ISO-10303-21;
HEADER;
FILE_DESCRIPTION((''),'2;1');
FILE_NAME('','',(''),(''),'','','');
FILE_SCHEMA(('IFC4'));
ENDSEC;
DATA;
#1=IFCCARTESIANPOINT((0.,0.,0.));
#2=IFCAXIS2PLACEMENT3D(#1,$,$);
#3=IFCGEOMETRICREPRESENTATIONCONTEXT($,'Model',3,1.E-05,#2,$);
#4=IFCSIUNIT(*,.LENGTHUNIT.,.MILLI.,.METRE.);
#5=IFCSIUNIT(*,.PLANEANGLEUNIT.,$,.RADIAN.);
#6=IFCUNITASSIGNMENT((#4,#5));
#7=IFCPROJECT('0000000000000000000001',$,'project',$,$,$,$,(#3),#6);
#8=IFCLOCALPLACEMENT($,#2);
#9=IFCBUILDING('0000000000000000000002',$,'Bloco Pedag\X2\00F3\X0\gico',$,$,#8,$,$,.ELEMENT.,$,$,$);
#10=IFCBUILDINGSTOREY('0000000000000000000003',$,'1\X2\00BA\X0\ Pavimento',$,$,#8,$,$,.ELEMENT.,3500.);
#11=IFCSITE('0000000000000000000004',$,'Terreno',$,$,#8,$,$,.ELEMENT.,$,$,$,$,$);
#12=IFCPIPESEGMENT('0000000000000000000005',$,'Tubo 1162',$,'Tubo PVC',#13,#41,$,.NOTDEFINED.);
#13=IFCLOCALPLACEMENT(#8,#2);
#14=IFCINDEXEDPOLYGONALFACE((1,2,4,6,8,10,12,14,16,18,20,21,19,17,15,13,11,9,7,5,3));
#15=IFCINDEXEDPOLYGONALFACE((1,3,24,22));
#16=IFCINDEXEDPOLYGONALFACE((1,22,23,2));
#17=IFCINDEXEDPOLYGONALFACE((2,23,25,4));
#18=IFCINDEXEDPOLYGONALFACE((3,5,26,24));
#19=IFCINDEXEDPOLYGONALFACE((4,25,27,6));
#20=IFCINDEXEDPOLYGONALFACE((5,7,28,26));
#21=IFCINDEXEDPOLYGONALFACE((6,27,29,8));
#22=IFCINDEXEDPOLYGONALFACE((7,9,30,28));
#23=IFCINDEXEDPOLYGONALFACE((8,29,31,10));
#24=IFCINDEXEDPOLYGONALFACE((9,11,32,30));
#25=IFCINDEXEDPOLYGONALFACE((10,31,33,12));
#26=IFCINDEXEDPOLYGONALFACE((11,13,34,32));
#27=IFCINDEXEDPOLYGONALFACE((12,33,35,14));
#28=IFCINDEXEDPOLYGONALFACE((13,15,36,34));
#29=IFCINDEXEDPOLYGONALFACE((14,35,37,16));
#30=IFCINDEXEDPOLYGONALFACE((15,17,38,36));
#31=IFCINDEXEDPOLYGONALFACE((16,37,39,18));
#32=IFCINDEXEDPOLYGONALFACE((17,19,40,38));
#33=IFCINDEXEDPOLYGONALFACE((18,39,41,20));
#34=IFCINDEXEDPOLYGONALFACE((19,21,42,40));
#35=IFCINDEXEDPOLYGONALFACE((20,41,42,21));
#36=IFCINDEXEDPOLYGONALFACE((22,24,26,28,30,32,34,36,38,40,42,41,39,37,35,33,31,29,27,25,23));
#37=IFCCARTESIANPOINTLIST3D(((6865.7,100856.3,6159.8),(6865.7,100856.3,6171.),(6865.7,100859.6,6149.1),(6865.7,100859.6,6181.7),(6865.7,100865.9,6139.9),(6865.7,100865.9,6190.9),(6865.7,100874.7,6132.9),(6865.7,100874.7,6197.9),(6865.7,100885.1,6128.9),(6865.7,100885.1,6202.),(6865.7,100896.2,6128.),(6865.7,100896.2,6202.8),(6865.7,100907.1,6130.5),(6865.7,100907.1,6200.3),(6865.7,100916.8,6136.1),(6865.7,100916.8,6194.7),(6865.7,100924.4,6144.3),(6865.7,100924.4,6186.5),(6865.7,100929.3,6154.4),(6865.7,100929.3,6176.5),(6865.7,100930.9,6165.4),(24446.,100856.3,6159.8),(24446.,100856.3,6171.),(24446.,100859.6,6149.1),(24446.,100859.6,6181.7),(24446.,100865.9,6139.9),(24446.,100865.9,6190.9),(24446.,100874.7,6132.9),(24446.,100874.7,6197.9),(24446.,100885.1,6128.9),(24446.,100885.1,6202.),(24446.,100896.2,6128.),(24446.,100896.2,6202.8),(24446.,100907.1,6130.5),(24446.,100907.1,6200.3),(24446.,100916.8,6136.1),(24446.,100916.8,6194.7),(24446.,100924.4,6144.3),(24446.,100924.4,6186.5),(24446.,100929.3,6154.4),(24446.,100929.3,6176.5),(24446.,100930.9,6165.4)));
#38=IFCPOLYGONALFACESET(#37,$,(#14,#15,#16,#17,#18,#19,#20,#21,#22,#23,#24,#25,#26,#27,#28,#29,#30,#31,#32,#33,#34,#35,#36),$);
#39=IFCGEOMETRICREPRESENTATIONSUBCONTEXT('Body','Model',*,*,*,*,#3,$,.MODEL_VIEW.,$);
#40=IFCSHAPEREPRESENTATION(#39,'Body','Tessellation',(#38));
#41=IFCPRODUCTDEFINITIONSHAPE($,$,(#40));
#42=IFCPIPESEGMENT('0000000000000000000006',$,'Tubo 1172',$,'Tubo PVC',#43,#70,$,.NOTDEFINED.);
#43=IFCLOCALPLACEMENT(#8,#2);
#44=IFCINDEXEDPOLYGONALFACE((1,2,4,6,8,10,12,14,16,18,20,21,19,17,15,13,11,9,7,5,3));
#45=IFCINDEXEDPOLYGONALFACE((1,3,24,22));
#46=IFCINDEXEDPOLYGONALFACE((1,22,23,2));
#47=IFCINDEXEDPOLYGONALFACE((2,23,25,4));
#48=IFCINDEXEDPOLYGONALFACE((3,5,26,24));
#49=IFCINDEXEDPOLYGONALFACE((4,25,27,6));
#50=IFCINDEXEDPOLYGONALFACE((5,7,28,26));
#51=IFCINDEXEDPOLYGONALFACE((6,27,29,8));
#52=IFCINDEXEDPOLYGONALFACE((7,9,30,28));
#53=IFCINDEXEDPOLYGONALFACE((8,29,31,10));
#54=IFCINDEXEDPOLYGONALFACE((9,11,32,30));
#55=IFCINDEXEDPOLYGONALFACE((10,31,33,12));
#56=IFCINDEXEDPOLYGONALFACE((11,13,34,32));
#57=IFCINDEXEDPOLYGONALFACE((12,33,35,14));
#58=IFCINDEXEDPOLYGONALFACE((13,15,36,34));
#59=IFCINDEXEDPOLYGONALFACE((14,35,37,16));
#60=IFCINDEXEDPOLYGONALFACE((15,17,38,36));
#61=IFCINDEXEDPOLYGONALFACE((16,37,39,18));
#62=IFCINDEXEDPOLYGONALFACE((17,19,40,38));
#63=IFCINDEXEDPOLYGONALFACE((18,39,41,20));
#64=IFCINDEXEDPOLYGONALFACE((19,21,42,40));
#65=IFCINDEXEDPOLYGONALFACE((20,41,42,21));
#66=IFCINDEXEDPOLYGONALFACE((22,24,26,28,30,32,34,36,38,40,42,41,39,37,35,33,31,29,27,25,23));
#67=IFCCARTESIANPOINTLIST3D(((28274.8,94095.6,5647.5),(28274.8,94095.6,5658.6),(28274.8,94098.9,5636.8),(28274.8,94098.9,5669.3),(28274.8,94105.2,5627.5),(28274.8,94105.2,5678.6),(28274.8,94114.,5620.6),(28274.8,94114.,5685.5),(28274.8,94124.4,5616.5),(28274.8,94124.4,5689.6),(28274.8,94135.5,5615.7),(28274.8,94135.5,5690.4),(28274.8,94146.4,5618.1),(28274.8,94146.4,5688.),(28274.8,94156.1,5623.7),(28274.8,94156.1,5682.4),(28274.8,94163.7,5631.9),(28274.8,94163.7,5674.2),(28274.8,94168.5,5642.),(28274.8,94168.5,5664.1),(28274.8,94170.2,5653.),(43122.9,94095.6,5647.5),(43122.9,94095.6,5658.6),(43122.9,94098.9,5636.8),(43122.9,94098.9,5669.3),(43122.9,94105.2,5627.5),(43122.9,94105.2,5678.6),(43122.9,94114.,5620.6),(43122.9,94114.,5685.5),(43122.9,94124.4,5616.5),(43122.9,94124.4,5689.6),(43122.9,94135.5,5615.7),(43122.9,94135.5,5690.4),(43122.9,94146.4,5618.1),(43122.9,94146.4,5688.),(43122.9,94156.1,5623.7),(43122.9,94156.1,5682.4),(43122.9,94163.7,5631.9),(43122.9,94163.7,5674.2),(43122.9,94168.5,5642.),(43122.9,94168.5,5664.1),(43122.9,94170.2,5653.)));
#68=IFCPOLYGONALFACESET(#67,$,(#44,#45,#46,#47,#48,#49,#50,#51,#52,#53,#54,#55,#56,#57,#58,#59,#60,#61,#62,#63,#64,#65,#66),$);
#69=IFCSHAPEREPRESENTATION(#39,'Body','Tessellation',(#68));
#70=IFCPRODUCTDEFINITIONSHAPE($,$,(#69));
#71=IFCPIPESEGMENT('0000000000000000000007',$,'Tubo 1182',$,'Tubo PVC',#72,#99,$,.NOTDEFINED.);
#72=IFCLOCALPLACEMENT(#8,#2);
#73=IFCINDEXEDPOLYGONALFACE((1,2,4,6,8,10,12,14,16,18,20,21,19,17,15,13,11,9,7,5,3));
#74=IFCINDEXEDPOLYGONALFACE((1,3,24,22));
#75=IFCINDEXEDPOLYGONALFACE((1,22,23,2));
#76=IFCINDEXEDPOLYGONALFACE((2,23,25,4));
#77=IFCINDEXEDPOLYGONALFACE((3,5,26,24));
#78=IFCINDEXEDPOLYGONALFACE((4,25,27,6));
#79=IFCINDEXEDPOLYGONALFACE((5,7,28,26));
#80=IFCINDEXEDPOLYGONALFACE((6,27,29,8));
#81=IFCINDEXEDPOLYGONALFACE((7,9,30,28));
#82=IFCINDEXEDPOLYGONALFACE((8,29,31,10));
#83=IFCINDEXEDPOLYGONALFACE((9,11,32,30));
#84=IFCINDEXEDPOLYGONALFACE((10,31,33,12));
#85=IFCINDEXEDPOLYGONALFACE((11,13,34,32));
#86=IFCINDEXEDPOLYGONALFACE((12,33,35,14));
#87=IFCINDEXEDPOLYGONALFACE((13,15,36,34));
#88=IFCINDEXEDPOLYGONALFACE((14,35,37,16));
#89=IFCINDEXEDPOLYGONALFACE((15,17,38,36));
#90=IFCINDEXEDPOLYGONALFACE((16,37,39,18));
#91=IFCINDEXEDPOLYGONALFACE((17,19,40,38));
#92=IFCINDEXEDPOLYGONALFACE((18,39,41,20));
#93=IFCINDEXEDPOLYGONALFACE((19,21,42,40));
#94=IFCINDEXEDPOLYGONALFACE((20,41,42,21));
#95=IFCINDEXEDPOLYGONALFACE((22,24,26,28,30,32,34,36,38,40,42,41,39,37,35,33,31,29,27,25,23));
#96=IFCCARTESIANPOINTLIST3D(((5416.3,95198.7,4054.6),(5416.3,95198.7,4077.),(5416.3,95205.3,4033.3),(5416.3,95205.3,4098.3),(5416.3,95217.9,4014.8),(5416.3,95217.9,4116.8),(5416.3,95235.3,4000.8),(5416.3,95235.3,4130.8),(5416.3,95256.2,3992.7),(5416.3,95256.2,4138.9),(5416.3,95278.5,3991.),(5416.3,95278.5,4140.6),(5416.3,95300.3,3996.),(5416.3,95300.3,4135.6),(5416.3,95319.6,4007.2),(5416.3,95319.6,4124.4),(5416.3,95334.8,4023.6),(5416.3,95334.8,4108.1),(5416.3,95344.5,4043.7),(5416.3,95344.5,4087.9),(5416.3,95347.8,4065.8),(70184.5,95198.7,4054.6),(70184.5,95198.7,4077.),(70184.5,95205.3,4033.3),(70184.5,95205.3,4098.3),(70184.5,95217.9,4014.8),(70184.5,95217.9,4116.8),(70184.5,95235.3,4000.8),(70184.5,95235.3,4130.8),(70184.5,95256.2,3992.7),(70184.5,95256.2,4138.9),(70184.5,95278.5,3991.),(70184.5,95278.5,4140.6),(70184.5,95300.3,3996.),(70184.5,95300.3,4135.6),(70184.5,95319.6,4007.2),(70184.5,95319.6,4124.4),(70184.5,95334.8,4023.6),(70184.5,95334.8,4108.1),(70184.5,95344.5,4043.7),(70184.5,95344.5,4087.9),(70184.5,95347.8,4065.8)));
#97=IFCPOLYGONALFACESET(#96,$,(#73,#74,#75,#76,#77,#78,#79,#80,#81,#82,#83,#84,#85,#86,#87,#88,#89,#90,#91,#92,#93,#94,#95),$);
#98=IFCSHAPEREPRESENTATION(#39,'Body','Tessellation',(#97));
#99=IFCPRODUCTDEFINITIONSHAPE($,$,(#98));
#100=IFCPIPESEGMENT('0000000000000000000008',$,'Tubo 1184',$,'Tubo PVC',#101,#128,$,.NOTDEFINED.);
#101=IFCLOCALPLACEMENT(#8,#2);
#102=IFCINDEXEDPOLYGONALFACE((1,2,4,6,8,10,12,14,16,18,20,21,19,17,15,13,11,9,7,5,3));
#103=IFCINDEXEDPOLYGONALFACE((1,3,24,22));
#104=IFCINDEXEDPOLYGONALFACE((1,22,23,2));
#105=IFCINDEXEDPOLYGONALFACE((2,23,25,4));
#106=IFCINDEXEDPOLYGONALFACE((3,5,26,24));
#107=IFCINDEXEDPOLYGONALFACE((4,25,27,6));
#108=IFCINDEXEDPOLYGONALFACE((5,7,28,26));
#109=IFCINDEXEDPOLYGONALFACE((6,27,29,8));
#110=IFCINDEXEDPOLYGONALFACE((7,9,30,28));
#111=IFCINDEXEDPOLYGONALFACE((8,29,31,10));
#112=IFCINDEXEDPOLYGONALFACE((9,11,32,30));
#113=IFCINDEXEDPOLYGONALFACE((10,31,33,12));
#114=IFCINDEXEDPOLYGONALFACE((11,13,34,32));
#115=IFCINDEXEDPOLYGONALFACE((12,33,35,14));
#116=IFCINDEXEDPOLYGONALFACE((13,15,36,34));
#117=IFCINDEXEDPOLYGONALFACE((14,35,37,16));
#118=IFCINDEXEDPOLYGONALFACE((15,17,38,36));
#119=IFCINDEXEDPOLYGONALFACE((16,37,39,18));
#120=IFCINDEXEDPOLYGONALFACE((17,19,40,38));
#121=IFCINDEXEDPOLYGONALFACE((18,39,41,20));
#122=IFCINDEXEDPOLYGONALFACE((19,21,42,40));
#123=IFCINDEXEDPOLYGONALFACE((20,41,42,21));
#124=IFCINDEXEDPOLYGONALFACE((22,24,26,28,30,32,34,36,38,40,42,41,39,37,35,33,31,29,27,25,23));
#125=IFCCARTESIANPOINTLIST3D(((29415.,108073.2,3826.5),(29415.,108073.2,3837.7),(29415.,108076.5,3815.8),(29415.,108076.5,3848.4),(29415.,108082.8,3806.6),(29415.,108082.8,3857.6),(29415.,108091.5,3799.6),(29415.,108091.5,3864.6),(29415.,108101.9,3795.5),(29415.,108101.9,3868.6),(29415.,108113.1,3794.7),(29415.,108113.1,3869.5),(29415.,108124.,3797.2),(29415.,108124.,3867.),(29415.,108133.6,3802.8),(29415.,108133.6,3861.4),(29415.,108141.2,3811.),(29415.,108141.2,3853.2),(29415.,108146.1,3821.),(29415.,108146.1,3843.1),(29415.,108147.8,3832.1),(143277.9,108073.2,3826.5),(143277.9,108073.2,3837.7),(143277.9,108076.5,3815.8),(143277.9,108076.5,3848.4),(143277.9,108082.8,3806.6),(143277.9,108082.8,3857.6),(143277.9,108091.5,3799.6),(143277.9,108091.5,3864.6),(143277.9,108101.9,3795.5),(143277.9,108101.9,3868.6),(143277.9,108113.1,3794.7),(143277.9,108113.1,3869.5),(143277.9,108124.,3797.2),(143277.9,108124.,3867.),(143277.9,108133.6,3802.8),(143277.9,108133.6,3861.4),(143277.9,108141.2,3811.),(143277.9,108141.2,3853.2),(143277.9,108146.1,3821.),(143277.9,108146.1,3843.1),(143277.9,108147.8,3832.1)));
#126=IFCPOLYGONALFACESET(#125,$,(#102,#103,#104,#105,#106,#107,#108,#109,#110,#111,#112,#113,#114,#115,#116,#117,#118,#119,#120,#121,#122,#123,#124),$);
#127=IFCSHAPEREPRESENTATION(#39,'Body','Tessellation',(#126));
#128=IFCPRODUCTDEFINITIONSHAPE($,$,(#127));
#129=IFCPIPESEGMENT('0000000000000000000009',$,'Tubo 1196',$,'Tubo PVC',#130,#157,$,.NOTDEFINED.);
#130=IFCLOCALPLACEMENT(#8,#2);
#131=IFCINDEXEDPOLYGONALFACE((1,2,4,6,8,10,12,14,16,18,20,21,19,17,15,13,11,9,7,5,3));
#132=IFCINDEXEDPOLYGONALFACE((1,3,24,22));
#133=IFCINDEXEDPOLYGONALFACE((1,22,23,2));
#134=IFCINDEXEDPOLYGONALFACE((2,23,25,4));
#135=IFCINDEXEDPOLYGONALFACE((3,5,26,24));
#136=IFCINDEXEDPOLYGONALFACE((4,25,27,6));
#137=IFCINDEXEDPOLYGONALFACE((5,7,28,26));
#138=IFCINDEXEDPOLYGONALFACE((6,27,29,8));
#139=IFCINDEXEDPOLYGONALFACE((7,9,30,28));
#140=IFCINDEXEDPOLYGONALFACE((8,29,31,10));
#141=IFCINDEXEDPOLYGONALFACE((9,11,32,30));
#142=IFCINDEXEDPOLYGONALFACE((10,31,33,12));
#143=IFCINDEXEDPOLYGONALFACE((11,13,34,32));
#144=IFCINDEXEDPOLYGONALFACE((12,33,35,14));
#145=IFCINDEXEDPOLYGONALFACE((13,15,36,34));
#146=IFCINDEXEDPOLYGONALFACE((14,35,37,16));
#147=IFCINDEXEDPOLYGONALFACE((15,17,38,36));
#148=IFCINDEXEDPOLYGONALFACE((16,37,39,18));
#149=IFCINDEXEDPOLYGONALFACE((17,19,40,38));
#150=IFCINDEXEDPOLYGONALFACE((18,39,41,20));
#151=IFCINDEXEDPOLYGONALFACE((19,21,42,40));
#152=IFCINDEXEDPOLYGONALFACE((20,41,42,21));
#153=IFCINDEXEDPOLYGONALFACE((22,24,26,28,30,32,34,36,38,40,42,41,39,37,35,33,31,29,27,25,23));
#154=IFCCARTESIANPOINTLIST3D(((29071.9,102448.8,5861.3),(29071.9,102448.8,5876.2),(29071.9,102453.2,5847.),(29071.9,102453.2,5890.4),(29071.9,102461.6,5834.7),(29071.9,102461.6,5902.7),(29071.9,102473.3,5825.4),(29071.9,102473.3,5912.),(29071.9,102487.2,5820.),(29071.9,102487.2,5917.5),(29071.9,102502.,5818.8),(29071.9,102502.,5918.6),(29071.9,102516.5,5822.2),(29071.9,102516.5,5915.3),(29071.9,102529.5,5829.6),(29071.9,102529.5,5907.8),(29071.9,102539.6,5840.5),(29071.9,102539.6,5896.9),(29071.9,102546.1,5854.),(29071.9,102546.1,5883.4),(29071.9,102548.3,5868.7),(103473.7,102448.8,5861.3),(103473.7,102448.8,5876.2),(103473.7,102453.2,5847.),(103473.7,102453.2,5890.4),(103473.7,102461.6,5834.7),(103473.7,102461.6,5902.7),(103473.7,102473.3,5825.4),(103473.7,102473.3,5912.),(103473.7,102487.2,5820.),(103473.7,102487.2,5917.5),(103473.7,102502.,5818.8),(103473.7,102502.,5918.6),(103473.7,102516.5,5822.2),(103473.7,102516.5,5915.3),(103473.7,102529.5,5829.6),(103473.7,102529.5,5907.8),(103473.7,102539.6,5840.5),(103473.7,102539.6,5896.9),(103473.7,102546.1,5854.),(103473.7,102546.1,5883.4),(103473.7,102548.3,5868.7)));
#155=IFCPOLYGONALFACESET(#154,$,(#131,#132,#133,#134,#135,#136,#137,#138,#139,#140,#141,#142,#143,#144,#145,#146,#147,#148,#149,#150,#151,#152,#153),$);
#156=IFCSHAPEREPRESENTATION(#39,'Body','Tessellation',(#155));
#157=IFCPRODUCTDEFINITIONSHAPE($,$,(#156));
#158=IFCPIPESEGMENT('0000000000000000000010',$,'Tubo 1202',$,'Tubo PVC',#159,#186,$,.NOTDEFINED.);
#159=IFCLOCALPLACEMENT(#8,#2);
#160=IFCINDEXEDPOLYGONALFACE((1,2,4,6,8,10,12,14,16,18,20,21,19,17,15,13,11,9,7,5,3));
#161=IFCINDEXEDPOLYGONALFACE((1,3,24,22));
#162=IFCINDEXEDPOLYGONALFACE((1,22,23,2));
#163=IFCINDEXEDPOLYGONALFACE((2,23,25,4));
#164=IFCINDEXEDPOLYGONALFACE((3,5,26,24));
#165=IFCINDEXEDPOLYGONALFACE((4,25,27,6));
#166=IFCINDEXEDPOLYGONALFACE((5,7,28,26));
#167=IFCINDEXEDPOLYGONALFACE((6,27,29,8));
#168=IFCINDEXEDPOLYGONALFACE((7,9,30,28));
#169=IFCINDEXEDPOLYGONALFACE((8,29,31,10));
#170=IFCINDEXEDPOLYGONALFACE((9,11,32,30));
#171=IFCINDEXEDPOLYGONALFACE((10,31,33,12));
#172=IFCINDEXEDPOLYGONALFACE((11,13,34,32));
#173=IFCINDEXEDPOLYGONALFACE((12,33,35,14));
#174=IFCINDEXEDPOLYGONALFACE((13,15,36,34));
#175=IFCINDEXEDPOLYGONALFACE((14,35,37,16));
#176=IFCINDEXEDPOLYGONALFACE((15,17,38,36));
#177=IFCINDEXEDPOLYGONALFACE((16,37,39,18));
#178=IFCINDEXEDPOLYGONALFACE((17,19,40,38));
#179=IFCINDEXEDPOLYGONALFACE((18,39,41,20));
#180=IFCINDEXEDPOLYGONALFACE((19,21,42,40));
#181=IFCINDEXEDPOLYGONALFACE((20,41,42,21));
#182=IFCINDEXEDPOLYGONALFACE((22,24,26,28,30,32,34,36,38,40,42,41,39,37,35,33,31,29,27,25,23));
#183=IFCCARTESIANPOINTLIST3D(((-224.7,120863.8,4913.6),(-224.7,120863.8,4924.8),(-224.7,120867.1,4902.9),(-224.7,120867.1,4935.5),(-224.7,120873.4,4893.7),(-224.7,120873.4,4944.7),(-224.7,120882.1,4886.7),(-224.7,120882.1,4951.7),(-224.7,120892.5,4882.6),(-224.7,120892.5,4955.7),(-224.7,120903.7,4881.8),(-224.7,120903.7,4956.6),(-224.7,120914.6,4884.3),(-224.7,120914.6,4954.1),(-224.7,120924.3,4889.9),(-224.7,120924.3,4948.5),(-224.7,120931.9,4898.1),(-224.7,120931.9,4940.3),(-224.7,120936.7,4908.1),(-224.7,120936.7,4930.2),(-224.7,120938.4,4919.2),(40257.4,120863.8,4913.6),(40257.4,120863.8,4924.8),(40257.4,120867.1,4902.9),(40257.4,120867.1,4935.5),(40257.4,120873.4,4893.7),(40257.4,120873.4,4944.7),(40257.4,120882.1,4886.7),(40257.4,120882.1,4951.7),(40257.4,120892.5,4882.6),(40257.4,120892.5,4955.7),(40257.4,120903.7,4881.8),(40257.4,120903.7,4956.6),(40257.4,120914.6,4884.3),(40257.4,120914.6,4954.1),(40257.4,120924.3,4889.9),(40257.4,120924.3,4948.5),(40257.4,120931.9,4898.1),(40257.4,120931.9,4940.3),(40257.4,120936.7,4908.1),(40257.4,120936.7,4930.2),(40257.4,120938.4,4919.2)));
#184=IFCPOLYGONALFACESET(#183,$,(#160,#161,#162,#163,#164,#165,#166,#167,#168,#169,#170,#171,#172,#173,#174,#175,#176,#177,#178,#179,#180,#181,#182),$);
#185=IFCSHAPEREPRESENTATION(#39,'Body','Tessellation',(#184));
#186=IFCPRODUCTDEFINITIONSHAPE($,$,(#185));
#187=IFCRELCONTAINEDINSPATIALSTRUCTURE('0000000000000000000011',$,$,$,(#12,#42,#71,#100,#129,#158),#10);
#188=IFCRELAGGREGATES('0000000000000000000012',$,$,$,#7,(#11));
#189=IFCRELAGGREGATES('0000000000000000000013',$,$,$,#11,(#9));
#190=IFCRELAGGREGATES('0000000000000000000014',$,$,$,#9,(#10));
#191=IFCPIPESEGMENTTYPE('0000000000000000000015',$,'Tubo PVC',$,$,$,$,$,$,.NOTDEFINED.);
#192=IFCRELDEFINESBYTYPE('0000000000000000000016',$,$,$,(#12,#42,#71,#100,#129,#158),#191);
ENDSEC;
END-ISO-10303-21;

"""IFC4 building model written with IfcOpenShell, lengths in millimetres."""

from ifc_helpers import new_model, si_unit, frame, origin, origin_2d, place, context, subcontext, project, spatial, circle, extrude, type_object, element, save


model = new_model("IFC4")

# Units and contexts
model_context = context("Model", 3, precision=1e-05, world=origin())
body_context = subcontext(model_context, "Body", "Model", "MODEL_VIEW")
ifc_project = project(units=[si_unit("LENGTHUNIT", "METRE", prefix="MILLI"), si_unit("PLANEANGLEUNIT", "RADIAN")], contexts=[model_context])

# Site, building, storey
placement = place(None, origin())
site = spatial("IfcSite", under=ifc_project, at=placement, Name="Terreno", CompositionType="ELEMENT")
building = spatial("IfcBuilding", under=site, at=placement, Name="Bloco Pedagógico", CompositionType="ELEMENT")
storey = spatial("IfcBuildingStorey", under=building, at=placement, Name="1º Pavimento", CompositionType="ELEMENT", Elevation=3500.0)

# Pipe segments
pipe_segment_type = type_object("IfcPipeSegmentType", Name="Tubo PVC", PredefinedType="NOTDEFINED")
pipe_segment_1_placement = place(None, frame((6865.7, 100893.4, 6165.4), z_axis=(1.0, 0.0, 0.0), x_axis=(0.0, 1.0, 0.0)))
element("IfcPipeSegment", 1, at=pipe_segment_1_placement, inside=storey, type_object=pipe_segment_type, Name="Tubo 1162", ObjectType="Tubo PVC", PredefinedType="NOTDEFINED", context=body_context, shape_type="SweptSolid", body=[
    extrude(circle(Radius=37.5, at=origin_2d()), None, (0.0, 0.0, 1.0), 17580.3),
])
pipe_segment_2_placement = place(None, frame((28274.8, 94132.7, 5653.0), z_axis=(1.0, 0.0, 0.0), x_axis=(0.0, 1.0, 0.0)))
element("IfcPipeSegment", 2, at=pipe_segment_2_placement, inside=storey, type_object=pipe_segment_type, Name="Tubo 1172", ObjectType="Tubo PVC", PredefinedType="NOTDEFINED", context=body_context, shape_type="SweptSolid", body=[
    extrude(circle(Radius=37.5, at=origin_2d()), None, (0.0, 0.0, 1.0), 14848.2),
])
pipe_segment_3_placement = place(None, frame((5416.3, 95272.8, 4065.8), z_axis=(1.0, 0.0, 0.0), x_axis=(0.0, 1.0, 0.0)))
element("IfcPipeSegment", 3, at=pipe_segment_3_placement, inside=storey, type_object=pipe_segment_type, Name="Tubo 1182", ObjectType="Tubo PVC", PredefinedType="NOTDEFINED", context=body_context, shape_type="SweptSolid", body=[
    extrude(circle(Radius=75.0, at=origin_2d()), None, (0.0, 0.0, 1.0), 64768.1),
])
pipe_segment_4_placement = place(None, frame((29415.0, 108110.3, 3832.1), z_axis=(1.0, 0.0, 0.0), x_axis=(0.0, 1.0, 0.0)))
element("IfcPipeSegment", 4, at=pipe_segment_4_placement, inside=storey, type_object=pipe_segment_type, Name="Tubo 1184", ObjectType="Tubo PVC", PredefinedType="NOTDEFINED", context=body_context, shape_type="SweptSolid", body=[
    extrude(circle(Radius=37.5, at=origin_2d()), None, (0.0, 0.0, 1.0), 113862.8),
])
pipe_segment_5_placement = place(None, frame((29071.9, 102498.3, 5868.7), z_axis=(1.0, 0.0, 0.0), x_axis=(0.0, 1.0, 0.0)))
element("IfcPipeSegment", 5, at=pipe_segment_5_placement, inside=storey, type_object=pipe_segment_type, Name="Tubo 1196", ObjectType="Tubo PVC", PredefinedType="NOTDEFINED", context=body_context, shape_type="SweptSolid", body=[
    extrude(circle(Radius=50.0, at=origin_2d()), None, (0.0, 0.0, 1.0), 74401.8),
])
pipe_segment_6_placement = place(None, frame((-224.7, 120900.9, 4919.2), z_axis=(1.0, 0.0, 0.0), x_axis=(0.0, 1.0, 0.0)))
element("IfcPipeSegment", 6, at=pipe_segment_6_placement, inside=storey, type_object=pipe_segment_type, Name="Tubo 1202", ObjectType="Tubo PVC", PredefinedType="NOTDEFINED", context=body_context, shape_type="SweptSolid", body=[
    extrude(circle(Radius=37.5, at=origin_2d()), None, (0.0, 0.0, 1.0), 40482.1),
])

save(model, "model.ifc")
